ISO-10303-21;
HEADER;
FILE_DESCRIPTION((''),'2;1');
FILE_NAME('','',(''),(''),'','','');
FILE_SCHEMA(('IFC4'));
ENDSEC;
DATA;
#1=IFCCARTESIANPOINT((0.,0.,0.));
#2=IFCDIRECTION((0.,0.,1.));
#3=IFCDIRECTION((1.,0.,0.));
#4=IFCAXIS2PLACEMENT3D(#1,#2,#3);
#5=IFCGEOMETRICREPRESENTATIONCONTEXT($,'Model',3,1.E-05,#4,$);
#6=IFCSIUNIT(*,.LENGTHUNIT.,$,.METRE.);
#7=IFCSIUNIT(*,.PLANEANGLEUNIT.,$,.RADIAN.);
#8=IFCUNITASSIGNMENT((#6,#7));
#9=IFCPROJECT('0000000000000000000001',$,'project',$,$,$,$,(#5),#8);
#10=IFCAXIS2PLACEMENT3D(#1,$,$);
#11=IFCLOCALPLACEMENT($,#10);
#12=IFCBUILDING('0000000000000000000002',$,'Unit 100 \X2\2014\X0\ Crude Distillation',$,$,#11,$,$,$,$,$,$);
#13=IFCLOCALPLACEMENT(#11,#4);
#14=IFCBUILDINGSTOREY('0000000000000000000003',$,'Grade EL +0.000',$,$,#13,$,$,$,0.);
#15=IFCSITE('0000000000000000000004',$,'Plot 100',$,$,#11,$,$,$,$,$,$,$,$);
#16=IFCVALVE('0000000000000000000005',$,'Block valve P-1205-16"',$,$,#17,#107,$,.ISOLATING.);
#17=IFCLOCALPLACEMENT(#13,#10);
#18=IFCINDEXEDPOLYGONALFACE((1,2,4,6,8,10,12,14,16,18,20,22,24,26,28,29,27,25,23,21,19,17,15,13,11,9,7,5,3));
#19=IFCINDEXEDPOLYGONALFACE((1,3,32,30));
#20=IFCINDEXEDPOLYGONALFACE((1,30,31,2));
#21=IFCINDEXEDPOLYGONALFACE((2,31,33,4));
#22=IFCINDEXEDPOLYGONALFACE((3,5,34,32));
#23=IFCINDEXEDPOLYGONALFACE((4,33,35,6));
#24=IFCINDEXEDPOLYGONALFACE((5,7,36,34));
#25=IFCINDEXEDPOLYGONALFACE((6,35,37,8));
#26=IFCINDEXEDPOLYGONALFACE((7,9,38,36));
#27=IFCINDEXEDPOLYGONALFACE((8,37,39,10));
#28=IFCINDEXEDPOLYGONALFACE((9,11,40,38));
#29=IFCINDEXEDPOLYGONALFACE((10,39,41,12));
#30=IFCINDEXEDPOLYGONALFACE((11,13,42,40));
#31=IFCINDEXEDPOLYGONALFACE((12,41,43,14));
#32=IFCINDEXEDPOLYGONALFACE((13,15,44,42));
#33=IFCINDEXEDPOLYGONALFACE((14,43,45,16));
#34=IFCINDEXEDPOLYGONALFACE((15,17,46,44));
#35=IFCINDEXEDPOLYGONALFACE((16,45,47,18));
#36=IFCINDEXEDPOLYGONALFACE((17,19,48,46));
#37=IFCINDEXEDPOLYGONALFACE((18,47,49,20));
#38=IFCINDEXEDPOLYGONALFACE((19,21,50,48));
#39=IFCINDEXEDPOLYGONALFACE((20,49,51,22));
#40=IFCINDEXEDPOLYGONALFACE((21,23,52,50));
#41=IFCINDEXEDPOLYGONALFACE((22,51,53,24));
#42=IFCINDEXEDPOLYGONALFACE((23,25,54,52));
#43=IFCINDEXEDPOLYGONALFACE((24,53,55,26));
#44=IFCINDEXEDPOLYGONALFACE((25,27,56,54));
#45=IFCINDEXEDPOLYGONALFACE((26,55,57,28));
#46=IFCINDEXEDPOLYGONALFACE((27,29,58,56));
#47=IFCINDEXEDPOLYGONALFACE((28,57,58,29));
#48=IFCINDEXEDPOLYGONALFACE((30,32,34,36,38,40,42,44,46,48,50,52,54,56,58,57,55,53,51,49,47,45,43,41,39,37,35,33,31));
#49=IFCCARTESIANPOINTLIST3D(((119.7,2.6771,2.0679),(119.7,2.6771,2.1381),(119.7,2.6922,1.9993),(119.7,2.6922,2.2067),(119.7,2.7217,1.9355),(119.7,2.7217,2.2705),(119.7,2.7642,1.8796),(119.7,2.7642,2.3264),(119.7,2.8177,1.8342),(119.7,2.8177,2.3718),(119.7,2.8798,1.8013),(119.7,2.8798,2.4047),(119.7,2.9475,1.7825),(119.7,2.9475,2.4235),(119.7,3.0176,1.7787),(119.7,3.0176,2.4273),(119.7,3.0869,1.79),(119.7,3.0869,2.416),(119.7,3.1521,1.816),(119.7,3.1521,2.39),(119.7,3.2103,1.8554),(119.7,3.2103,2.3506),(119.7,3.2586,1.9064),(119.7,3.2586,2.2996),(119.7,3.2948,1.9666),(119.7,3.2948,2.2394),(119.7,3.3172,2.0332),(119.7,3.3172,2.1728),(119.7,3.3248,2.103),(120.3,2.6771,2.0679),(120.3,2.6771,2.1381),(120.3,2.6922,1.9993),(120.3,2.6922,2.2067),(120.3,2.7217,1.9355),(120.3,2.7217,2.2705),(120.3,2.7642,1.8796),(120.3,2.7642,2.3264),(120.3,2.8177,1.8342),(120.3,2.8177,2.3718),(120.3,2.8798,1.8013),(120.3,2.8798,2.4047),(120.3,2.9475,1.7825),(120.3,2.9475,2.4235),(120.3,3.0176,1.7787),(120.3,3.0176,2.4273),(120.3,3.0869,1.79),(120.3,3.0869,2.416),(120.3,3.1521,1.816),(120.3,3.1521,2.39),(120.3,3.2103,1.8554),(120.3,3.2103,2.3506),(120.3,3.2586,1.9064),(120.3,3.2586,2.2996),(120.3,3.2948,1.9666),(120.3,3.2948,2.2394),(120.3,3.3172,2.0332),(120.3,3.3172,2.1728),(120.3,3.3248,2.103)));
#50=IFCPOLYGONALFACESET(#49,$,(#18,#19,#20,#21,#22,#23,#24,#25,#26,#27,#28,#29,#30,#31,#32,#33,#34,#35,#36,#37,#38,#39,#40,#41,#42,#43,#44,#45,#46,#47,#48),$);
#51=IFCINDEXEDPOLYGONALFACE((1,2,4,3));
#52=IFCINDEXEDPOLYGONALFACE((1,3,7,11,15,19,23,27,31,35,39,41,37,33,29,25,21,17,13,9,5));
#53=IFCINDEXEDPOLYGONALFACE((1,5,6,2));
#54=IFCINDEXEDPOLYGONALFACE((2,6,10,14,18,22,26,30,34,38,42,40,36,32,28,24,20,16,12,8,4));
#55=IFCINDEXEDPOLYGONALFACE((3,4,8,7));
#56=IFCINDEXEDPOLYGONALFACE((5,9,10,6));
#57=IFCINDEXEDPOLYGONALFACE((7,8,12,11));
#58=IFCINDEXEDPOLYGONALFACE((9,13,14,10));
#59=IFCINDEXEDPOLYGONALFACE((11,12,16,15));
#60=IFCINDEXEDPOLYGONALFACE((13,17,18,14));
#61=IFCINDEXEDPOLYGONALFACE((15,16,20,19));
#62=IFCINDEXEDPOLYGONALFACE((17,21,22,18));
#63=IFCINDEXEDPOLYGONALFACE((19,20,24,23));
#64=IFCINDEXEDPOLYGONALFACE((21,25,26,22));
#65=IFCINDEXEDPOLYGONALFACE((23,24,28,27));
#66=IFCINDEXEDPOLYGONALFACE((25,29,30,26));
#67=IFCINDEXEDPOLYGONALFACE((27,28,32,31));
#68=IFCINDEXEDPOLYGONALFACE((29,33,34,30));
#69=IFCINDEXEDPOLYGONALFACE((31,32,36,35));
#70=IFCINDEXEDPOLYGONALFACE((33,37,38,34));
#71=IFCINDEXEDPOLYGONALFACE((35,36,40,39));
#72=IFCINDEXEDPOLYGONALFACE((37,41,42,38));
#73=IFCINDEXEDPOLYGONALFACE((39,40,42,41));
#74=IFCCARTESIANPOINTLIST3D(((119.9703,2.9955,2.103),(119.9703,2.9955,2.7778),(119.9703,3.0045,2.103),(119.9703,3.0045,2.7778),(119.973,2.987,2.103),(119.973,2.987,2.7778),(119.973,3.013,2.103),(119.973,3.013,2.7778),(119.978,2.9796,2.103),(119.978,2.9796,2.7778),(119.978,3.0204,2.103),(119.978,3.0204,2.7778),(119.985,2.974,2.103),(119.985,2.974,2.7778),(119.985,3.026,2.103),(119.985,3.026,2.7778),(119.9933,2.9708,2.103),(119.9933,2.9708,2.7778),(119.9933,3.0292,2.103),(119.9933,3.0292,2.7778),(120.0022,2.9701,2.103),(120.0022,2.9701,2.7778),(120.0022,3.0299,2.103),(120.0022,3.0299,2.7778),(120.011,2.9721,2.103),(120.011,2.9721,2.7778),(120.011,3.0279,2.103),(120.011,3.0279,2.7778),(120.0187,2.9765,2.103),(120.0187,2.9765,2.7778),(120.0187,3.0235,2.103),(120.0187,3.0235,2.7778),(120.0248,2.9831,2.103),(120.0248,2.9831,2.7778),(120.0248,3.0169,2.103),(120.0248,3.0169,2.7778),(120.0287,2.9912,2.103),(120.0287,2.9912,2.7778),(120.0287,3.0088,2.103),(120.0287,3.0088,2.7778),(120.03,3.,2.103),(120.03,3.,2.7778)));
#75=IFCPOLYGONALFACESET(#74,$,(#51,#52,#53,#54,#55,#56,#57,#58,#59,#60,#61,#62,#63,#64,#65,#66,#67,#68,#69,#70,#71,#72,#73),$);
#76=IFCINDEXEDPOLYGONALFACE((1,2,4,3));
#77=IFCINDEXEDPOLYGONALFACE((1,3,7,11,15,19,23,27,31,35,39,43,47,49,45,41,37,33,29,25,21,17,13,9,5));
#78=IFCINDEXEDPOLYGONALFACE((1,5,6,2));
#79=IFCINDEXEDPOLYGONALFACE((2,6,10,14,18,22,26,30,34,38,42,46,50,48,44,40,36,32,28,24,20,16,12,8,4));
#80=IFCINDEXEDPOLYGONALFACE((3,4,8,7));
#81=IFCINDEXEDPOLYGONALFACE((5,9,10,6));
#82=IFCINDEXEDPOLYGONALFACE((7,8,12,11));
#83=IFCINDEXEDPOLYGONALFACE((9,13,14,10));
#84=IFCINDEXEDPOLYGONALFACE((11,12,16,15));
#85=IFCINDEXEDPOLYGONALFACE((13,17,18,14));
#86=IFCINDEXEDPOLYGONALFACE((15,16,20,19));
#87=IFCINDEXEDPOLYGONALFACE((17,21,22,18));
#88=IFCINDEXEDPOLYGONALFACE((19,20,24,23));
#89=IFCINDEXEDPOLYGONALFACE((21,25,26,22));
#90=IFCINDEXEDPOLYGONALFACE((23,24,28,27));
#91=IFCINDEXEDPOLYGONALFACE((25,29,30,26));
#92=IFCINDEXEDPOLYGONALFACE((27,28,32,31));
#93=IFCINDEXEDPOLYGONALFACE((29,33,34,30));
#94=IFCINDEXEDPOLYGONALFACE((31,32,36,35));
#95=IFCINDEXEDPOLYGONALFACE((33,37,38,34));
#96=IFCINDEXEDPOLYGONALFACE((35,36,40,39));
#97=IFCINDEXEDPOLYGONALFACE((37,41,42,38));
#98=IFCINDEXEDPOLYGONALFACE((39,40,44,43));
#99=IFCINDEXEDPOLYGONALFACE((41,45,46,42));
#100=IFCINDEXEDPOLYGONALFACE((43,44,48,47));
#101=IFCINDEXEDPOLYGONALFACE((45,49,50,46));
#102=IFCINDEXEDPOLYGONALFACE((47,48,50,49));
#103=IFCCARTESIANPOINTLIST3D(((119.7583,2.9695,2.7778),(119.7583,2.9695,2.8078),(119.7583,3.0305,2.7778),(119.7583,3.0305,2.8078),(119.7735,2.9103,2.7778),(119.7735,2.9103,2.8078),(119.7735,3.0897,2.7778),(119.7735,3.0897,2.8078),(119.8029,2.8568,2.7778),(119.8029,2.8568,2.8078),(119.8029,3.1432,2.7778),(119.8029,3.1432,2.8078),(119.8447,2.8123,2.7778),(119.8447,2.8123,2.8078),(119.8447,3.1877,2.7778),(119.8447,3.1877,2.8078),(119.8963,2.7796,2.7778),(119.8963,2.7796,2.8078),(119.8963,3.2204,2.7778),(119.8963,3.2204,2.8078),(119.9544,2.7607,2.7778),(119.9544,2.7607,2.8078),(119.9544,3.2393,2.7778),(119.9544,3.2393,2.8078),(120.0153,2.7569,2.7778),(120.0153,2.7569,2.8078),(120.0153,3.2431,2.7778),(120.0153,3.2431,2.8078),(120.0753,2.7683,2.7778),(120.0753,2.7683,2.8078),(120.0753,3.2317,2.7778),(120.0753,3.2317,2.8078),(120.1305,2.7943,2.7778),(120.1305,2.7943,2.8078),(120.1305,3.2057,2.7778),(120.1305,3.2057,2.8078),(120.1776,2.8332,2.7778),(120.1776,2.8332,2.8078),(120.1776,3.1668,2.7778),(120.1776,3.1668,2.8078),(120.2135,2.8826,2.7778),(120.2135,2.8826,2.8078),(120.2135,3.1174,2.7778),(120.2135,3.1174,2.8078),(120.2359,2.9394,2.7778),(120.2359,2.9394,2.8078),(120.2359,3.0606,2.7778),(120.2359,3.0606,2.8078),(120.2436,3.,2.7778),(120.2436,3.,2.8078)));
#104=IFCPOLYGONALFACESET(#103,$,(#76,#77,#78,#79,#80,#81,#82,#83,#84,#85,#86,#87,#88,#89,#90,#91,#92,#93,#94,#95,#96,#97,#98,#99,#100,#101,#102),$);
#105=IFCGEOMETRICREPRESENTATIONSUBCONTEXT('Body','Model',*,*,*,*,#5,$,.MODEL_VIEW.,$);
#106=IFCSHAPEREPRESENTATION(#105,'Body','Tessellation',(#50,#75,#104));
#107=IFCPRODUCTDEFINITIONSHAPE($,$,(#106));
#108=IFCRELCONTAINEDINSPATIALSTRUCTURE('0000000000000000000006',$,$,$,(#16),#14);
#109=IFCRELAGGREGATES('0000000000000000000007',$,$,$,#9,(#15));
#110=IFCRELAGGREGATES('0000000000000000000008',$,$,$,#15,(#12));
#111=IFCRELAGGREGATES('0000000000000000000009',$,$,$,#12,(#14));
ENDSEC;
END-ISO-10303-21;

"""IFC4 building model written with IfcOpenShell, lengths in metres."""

from ifc_helpers import new_model, si_unit, frame, origin, origin_with_axes, origin_2d, place, context, subcontext, project, spatial, circle, extrude, element, save


model = new_model("IFC4")

# Units and contexts
model_context = context("Model", 3, precision=1e-05, world=origin_with_axes())
body_context = subcontext(model_context, "Body", "Model", "MODEL_VIEW")
ifc_project = project(units=[si_unit("LENGTHUNIT", "METRE"), si_unit("PLANEANGLEUNIT", "RADIAN")], contexts=[model_context])

# Site, building, storey
placement = place(None, origin())
site = spatial("IfcSite", under=ifc_project, at=placement, Name="Plot 100")
building = spatial("IfcBuilding", under=site, at=placement, Name="Unit 100 — Crude Distillation")
storey_placement = place(placement, origin_with_axes())
storey = spatial("IfcBuildingStorey", under=building, at=storey_placement, Name="Grade EL +0.000", Elevation=0.0)

# Valve
valve_1_placement = place(storey_placement, origin_with_axes())
element("IfcValve", 1, at=valve_1_placement, inside=storey, Name="Block valve P-1205-16\"", PredefinedType="ISOLATING", context=body_context, shape_type="SweptSolid", body=[
    extrude(circle(Radius=0.3248, at=origin_2d()), frame((119.7, 3.0, 2.103), z_axis=(1.0, 0.0, 0.0), x_axis=(0.0, 1.0, 0.0)), (0.0, 0.0, 1.0), 0.6),
    extrude(circle(Radius=0.03, at=origin_2d()), frame((120.0, 3.0, 2.103), z_axis=(0.0, 0.0, 1.0), x_axis=(1.0, 0.0, 0.0)), (0.0, 0.0, 1.0), 0.6748),
    extrude(circle(Radius=0.2436, at=origin_2d()), frame((120.0, 3.0, 2.7778), z_axis=(0.0, 0.0, 1.0), x_axis=(1.0, 0.0, 0.0)), (0.0, 0.0, 1.0), 0.03),
])

save(model, "model.ifc")
